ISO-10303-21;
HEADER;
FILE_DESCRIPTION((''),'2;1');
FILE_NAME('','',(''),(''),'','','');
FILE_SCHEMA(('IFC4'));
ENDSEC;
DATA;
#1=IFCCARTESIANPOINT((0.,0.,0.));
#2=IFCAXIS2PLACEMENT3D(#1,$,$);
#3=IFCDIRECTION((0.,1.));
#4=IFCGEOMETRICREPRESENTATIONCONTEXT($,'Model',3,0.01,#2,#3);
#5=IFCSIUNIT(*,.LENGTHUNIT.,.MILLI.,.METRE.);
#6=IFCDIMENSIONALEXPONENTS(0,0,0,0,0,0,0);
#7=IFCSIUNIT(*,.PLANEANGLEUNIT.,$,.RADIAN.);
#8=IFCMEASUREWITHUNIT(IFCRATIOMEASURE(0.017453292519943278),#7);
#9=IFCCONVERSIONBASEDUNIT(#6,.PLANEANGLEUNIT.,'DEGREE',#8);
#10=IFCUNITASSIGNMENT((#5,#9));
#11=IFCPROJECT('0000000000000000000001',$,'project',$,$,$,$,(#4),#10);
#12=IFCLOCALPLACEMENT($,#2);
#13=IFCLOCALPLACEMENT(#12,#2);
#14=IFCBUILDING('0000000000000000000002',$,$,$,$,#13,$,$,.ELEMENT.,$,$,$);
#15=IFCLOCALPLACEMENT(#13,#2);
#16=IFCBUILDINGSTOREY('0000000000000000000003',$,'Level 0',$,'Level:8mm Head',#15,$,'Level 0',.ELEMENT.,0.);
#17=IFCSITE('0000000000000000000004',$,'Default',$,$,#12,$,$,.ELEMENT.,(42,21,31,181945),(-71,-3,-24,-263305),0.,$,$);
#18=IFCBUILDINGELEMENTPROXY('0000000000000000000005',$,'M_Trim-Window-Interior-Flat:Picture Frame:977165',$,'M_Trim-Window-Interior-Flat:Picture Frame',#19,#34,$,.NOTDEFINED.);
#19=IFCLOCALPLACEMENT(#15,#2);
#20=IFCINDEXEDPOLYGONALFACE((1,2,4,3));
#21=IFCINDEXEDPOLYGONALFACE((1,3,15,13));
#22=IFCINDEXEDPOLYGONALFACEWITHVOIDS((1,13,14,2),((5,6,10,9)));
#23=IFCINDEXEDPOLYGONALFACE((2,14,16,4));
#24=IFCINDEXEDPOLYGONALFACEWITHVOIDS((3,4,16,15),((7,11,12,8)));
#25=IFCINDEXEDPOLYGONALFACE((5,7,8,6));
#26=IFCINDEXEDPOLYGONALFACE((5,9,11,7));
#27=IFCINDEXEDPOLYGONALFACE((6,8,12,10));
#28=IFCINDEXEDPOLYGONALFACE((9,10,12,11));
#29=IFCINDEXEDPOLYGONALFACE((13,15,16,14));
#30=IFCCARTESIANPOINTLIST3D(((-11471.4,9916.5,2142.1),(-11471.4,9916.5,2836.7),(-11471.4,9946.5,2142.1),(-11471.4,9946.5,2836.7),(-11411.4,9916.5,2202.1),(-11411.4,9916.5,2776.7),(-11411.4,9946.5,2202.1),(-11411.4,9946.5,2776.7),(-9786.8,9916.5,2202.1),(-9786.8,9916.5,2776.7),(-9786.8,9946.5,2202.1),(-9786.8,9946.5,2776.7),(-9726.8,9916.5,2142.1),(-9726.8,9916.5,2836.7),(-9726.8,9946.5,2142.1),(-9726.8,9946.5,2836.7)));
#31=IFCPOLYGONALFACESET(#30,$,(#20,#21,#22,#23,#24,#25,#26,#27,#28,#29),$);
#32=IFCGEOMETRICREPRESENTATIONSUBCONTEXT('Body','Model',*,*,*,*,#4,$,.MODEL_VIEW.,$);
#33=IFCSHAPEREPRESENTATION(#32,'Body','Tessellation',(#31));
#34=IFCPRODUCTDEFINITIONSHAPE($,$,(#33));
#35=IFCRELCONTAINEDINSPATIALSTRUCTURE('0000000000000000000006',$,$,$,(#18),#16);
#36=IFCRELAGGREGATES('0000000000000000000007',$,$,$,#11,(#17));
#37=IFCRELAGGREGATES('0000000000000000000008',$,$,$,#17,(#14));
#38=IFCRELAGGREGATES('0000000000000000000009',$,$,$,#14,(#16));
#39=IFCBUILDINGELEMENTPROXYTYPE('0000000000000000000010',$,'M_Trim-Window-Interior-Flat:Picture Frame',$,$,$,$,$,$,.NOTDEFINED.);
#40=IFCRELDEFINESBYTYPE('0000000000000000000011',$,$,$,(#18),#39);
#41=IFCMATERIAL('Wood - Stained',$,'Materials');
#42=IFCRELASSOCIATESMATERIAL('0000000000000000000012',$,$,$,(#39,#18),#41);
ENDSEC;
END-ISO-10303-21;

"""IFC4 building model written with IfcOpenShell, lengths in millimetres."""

from ifc_helpers import new_model, entity, si_unit, converted_unit, direction, frame, origin, place, context, subcontext, project, spatial, polyline, outline, extrude, source, transform, mapped, material, type_object, type_shapes, element, save


model = new_model("IFC4")

# Units and contexts
model_context = context("Model", 3, precision=0.01, world=origin(), true_north=direction((0.0, 1.0)))
body_context = subcontext(model_context, "Body", "Model", "MODEL_VIEW")
ifc_project = project(units=[si_unit("LENGTHUNIT", "METRE", prefix="MILLI"), converted_unit("PLANEANGLEUNIT", "DEGREE", entity("IfcRatioMeasure", 0.017453292519943278), si_unit("PLANEANGLEUNIT", "RADIAN"), dimensions=[0, 0, 0, 0, 0, 0, 0])], contexts=[model_context])

# Site, building, storey
site_placement = place(None, origin())
site = spatial("IfcSite", under=ifc_project, at=site_placement, Name="Default", CompositionType="ELEMENT", RefLatitude=(42, 21, 31, 181945), RefLongitude=(-71, -3, -24, -263305), RefElevation=0.0)
building_placement = place(site_placement, origin())
building = spatial("IfcBuilding", under=site, at=building_placement, CompositionType="ELEMENT")
storey_placement = place(building_placement, origin())
storey = spatial("IfcBuildingStorey", under=building, at=storey_placement, Name="Level 0", ObjectType="Level:8mm Head", LongName="Level 0", CompositionType="ELEMENT", Elevation=0.0)

# Building element proxy
ifc_material_1 = material(Name="Wood - Stained", Category="Materials")
building_element_proxy_type_1 = type_object("IfcBuildingElementProxyType", Name="M_Trim-Window-Interior-Flat:Picture Frame", PredefinedType="NOTDEFINED", material=ifc_material_1)
shared_shape_1 = source(origin(), body_context, "Body", "SweptSolid", [
    extrude(outline(polyline([(-872.3, -347.3), (872.3, -347.3), (872.3, 347.3), (-872.3, 347.3), (-872.3, -347.3)]), holes=[polyline([(-812.3, -287.3), (-812.3, 287.3), (812.3, 287.3), (812.3, -287.3), (-812.3, -287.3)])]), frame((0.0, -300.0, 0.0), z_axis=(0.0, 0.0, 1.0), x_axis=(-1.0, 0.0, 0.0)), (0.0, 0.0, 1.0), 30.0),
])
type_shapes(building_element_proxy_type_1, [shared_shape_1])
for number, where, z_axis, x_axis, name in (
    (1, (-10599.1, 9946.5, 2789.4), (0.0, -1.0, 0.0), (1.0, 0.0, 0.0), "M_Trim-Window-Interior-Flat:Picture Frame:977165"),
):
    element("IfcBuildingElementProxy", number, at=place(storey_placement, frame(where, z_axis=z_axis, x_axis=x_axis)), inside=storey, type_object=building_element_proxy_type_1, material=ifc_material_1, Name=name, ObjectType="M_Trim-Window-Interior-Flat:Picture Frame", PredefinedType="NOTDEFINED", context=body_context, shape_type="MappedRepresentation", body=[
        mapped(shared_shape_1, transform((0.0, 0.0, 0.0), scale=1.0)),
    ])

save(model, "model.ifc")
